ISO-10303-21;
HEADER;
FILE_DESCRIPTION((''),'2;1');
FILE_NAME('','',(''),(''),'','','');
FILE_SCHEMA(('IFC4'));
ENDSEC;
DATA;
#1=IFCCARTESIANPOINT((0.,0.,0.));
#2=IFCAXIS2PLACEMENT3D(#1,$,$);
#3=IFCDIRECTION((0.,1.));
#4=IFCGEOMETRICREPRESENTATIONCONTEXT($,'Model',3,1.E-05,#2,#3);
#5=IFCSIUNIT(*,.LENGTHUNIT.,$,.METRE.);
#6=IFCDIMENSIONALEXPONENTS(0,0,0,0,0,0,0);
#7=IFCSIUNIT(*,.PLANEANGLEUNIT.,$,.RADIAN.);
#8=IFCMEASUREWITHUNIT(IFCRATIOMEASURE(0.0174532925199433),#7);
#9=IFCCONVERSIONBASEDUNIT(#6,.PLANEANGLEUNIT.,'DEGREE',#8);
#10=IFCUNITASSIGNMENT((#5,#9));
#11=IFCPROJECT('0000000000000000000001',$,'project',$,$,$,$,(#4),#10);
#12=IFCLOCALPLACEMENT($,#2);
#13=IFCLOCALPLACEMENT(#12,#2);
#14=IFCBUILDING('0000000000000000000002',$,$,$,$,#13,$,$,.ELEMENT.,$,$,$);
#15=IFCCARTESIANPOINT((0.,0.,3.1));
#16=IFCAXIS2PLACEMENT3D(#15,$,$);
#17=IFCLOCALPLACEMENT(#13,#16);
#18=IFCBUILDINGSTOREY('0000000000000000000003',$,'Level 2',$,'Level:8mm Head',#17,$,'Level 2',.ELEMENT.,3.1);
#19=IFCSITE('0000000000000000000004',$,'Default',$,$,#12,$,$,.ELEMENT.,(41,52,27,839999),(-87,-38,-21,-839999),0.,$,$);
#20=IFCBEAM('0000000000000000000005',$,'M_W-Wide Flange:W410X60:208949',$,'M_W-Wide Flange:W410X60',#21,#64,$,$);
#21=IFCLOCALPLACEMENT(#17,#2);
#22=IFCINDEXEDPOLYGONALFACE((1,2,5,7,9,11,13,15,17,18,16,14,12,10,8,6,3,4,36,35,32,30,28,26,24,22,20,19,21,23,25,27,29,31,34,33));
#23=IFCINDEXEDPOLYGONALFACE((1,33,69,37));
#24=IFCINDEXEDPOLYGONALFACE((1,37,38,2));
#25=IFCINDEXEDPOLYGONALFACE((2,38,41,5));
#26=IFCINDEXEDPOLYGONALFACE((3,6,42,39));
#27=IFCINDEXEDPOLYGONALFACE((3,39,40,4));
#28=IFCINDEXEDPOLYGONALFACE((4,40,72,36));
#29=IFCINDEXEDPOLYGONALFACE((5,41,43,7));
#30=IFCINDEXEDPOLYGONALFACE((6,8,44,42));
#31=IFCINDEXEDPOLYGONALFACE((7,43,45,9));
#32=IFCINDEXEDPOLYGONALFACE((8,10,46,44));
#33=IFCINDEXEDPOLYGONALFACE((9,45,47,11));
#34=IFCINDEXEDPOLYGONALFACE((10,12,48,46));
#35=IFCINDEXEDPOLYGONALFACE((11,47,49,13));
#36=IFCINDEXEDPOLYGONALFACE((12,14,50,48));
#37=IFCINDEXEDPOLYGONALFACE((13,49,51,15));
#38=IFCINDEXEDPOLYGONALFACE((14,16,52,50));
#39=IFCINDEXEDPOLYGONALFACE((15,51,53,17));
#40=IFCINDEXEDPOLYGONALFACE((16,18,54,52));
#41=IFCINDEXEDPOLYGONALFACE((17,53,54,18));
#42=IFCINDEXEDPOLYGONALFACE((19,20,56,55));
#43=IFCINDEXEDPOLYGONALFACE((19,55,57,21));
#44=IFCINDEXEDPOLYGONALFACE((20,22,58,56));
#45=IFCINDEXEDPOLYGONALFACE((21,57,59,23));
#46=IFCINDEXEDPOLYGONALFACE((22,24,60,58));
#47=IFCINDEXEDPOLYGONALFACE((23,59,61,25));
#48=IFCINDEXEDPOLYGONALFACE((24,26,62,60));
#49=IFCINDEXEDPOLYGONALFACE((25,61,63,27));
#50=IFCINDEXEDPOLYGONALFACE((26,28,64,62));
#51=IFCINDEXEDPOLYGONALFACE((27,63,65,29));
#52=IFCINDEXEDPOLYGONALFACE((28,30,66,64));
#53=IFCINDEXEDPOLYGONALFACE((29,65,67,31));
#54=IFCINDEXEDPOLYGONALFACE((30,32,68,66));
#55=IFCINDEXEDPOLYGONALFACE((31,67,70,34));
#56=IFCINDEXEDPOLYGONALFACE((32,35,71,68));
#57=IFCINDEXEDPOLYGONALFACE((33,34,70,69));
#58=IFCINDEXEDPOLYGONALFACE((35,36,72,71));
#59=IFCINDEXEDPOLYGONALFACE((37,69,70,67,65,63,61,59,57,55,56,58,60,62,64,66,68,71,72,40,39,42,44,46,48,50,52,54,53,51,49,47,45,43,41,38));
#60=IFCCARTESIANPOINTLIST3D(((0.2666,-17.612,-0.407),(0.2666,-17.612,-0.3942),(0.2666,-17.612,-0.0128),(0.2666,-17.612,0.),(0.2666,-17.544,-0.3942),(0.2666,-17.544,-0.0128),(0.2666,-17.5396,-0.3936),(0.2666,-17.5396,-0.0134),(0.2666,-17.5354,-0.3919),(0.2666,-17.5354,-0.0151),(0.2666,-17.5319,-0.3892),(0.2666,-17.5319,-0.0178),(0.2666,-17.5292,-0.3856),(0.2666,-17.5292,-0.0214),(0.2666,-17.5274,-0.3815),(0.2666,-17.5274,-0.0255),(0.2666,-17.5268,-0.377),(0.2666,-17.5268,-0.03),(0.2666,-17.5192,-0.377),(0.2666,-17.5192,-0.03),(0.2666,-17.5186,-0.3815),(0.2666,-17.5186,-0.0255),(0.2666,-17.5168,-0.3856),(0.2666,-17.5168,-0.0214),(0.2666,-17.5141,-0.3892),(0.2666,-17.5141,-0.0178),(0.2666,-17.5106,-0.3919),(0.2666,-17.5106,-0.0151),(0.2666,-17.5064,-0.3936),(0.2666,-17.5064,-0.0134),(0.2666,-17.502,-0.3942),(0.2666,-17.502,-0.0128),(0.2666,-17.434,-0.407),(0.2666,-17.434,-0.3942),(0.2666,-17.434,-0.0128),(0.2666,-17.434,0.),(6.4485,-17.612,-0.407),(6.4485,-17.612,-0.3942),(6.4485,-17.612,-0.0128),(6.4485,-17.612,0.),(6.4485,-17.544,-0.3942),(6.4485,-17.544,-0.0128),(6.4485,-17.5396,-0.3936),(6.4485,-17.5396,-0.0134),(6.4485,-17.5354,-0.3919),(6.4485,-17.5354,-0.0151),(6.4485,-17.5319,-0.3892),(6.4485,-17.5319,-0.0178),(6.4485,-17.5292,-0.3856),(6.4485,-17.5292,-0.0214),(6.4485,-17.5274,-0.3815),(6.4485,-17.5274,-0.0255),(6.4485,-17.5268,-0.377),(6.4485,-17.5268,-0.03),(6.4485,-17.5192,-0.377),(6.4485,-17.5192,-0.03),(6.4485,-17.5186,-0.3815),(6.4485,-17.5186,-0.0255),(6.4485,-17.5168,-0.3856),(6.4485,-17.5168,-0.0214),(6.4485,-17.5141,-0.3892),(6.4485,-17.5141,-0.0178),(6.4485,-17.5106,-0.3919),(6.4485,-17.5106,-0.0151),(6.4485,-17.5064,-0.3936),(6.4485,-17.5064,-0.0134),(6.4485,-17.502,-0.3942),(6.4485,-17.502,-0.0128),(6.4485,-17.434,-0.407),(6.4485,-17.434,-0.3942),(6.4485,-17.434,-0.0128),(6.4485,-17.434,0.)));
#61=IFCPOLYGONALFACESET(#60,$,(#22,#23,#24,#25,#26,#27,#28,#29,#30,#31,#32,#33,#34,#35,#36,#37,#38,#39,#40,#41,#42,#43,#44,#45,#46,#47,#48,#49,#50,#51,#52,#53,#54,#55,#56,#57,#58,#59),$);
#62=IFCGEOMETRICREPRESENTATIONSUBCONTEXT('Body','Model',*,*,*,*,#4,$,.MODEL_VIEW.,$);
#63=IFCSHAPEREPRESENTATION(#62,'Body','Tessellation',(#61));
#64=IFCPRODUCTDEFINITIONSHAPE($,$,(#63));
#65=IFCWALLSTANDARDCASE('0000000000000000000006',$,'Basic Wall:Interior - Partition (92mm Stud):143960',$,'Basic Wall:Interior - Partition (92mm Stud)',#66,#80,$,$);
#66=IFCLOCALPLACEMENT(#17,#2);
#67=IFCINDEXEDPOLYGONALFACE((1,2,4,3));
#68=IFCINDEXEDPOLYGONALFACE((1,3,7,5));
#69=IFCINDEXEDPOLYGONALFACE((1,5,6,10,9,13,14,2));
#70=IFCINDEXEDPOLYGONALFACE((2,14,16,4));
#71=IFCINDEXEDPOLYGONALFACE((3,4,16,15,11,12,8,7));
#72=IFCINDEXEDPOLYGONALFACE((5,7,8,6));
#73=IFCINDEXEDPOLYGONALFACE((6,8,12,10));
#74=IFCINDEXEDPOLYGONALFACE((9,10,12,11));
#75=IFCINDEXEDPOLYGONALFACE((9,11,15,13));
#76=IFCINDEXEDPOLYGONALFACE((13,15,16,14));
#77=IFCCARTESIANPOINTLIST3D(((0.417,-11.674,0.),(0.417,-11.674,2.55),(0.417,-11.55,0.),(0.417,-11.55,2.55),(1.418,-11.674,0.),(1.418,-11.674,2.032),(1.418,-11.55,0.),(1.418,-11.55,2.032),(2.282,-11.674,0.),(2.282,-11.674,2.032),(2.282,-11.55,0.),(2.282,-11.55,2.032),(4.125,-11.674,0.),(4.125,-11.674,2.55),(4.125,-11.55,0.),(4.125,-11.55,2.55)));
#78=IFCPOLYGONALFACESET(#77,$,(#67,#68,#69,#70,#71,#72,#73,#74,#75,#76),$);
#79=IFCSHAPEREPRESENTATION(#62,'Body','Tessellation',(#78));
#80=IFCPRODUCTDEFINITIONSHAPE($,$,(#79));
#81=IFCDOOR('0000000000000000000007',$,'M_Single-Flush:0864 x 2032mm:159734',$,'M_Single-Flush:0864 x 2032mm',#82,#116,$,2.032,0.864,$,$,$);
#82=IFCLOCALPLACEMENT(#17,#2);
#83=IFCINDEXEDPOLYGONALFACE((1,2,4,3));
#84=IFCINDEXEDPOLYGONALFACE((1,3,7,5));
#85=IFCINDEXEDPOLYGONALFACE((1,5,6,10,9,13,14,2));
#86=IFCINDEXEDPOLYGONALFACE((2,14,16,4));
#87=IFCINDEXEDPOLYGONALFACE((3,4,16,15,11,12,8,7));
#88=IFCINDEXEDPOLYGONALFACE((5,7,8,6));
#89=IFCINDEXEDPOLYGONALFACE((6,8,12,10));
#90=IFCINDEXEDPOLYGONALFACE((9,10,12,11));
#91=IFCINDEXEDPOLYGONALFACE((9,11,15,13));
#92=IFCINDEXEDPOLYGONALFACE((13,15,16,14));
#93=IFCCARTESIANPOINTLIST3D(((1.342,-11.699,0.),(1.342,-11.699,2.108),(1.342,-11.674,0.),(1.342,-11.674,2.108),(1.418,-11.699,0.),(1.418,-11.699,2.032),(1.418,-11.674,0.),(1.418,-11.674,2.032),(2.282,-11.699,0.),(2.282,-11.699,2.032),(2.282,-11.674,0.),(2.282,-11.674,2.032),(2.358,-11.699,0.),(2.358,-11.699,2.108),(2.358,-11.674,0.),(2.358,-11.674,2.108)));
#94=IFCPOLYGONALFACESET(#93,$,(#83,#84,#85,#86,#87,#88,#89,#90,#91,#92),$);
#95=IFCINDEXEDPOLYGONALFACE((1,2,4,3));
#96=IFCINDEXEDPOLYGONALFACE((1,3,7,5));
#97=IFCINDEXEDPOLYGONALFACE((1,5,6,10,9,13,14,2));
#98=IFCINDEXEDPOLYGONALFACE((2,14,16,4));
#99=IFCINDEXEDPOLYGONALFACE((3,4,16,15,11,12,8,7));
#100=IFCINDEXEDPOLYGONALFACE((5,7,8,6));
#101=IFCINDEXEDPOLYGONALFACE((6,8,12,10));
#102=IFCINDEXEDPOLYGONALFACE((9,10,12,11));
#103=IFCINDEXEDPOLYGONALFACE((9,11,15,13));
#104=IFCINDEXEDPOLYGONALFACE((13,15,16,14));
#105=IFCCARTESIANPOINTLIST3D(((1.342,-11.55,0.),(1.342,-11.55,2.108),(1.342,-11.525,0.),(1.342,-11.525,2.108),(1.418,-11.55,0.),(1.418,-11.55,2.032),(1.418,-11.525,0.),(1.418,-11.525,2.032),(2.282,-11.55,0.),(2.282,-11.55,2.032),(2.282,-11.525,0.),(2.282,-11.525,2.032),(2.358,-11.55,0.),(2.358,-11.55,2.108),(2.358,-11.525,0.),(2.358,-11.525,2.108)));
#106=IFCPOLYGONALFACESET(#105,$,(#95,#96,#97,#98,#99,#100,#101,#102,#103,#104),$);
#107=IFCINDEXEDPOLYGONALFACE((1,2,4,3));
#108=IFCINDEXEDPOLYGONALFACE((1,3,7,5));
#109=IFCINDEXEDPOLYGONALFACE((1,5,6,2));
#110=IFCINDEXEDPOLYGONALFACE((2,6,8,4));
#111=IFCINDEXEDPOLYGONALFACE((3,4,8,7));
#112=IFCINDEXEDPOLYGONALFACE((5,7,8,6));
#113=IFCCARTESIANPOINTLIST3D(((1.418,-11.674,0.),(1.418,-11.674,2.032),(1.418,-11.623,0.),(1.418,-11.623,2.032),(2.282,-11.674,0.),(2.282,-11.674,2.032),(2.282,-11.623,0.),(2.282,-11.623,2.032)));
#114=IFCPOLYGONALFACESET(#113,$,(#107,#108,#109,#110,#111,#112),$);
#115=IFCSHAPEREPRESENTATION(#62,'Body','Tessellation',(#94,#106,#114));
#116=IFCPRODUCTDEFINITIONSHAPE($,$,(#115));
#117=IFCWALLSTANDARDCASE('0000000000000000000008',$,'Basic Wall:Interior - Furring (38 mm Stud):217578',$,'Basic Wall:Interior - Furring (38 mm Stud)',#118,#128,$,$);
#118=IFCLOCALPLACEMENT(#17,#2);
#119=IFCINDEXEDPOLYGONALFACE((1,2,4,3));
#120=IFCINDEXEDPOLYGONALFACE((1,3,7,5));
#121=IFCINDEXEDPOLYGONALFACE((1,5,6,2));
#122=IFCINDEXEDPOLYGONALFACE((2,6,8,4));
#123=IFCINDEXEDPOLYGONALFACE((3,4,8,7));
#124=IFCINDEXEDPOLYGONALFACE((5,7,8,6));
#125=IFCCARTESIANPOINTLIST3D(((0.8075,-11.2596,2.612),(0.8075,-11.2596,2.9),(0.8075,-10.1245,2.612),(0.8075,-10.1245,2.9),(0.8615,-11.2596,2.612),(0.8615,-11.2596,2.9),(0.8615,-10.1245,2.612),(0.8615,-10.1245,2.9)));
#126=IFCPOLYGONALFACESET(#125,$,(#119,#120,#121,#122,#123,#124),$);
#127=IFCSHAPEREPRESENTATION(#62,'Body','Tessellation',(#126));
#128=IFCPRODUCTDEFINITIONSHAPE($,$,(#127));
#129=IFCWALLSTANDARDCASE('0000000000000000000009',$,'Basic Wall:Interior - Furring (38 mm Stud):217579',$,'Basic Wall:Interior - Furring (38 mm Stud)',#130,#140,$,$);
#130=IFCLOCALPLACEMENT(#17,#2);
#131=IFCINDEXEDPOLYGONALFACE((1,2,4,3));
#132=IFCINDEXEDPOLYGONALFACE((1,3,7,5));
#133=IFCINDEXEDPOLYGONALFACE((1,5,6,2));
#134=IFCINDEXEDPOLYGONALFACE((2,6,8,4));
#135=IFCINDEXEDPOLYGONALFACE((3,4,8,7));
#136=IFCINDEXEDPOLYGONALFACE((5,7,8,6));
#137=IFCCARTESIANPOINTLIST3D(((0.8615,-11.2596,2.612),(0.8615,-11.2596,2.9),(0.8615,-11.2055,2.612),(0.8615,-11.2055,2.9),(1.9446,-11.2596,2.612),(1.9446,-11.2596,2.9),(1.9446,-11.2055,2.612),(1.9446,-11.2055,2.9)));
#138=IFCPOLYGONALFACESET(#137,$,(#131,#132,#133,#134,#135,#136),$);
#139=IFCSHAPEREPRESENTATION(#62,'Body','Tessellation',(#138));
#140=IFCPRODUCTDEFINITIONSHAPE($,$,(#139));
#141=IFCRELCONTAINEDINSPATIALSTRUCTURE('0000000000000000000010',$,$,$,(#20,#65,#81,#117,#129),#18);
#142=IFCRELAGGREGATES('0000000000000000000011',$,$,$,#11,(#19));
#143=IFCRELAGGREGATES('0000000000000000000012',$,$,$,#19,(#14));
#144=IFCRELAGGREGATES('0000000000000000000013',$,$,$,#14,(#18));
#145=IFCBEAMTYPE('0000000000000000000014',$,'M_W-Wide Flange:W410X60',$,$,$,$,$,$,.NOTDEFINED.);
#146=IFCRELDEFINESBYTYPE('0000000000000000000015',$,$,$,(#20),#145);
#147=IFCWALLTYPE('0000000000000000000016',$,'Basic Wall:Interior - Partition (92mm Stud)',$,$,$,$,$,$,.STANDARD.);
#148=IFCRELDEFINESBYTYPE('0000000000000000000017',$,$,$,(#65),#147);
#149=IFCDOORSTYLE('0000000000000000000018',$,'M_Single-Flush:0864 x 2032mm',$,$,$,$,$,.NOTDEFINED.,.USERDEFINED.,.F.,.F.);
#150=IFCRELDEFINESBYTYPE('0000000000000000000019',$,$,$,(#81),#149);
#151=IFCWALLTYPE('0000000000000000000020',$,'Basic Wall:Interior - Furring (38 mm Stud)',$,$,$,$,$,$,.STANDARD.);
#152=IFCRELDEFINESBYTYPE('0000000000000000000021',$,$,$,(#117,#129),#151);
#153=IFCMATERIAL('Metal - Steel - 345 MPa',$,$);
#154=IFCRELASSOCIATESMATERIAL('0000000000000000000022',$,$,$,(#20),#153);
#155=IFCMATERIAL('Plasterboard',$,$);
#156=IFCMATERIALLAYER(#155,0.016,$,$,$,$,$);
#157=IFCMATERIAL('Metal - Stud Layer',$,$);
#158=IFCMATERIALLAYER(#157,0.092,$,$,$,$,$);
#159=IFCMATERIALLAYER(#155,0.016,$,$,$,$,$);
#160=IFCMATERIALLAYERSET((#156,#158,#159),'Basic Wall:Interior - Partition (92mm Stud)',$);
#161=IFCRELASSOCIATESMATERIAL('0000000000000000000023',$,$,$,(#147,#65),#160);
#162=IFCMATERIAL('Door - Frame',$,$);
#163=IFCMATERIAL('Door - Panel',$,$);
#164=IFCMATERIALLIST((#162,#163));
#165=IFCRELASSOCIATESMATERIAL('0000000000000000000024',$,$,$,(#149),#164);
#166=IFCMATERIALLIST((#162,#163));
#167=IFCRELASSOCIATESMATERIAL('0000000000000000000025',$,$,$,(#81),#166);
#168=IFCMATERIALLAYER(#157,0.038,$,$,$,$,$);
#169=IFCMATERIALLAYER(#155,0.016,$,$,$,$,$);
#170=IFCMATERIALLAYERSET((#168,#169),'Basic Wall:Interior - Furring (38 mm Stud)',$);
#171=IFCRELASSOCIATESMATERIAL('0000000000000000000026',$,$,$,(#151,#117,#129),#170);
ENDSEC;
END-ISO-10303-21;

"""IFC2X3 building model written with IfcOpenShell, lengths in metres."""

from ifc_helpers import new_model, entity, si_unit, converted_unit, direction, frame, frame_2d, origin, place, context, subcontext, project, spatial, polyline, rectangle, i_section, outline, extrude, source, transform, mapped, material, material_list, layer, layer_set, layer_usage, type_object, type_shapes, element, fill, save


model = new_model("IFC2X3")

# Units and contexts
model_context = context("Model", 3, precision=1e-05, world=origin(), true_north=direction((0.0, 1.0)))
body_context = subcontext(model_context, "Body", "Model", "MODEL_VIEW")
ifc_project = project(units=[si_unit("LENGTHUNIT", "METRE"), converted_unit("PLANEANGLEUNIT", "DEGREE", entity("IfcRatioMeasure", 0.0174532925199433), si_unit("PLANEANGLEUNIT", "RADIAN"), dimensions=[0, 0, 0, 0, 0, 0, 0])], contexts=[model_context])

# Site, building, storey
site_placement = place(None, origin())
site = spatial("IfcSite", under=ifc_project, at=site_placement, Name="Default", CompositionType="ELEMENT", RefLatitude=(41, 52, 27, 839999), RefLongitude=(-87, -38, -21, -839999), RefElevation=0.0)
building_placement = place(site_placement, origin())
building = spatial("IfcBuilding", under=site, at=building_placement, CompositionType="ELEMENT")
storey_placement = place(building_placement, frame((0.0, 0.0, 3.1)))
storey = spatial("IfcBuildingStorey", under=building, at=storey_placement, Name="Level 2", ObjectType="Level:8mm Head", LongName="Level 2", CompositionType="ELEMENT", Elevation=3.1)

# Beam
ifc_material_1 = material(Name="Metal - Steel - 345 MPa")
beam_type = type_object("IfcBeamType", Name="M_W-Wide Flange:W410X60", PredefinedType="NOTDEFINED")
beam_placement = place(storey_placement, frame((0.2666, -17.523, 0.0)))
element("IfcBeam", 1, at=beam_placement, inside=storey, type_object=beam_type, material=ifc_material_1, Name="M_W-Wide Flange:W410X60:208949", ObjectType="M_W-Wide Flange:W410X60", context=body_context, shape_type="SweptSolid", body=[
    extrude(i_section(OverallWidth=0.178, OverallDepth=0.407, WebThickness=0.0077, FlangeThickness=0.0128, FilletRadius=0.0172, at=frame_2d((0.0, 0.0), x_axis=(0.0, 1.0))), frame((0.0, 0.0, -0.2035), z_axis=(1.0, 0.0, 0.0), x_axis=(0.0, 0.0, -1.0)), (0.0, 0.0, 1.0), 6.1819),
])

# Shared definitions
ifc_material_2 = material(Name="Metal - Stud Layer")
ifc_material_3 = material(Name="Plasterboard")

# Wall, opening, door
ifc_layer_1 = layer(ifc_material_3, 0.016)
ifc_layer_2 = layer(ifc_material_2, 0.092)
ifc_layer_3 = layer(ifc_material_3, 0.016)
ifc_layer_set_1 = layer_set([ifc_layer_1, ifc_layer_2, ifc_layer_3], Name="Basic Wall:Interior - Partition (92mm Stud)")
ifc_layer_usage_1 = layer_usage(ifc_layer_set_1, "AXIS2", "NEGATIVE", 0.062)
wall_type_1 = type_object("IfcWallType", Name="Basic Wall:Interior - Partition (92mm Stud)", PredefinedType="STANDARD", material=ifc_layer_set_1)
wall_1_placement = place(storey_placement, frame((4.125, -11.612, 0.0), z_axis=(0.0, 0.0, 1.0), x_axis=(-1.0, 0.0, 0.0)))
wall_1 = element("IfcWallStandardCase", 2, at=wall_1_placement, inside=storey, type_object=wall_type_1, material=ifc_layer_usage_1, Name="Basic Wall:Interior - Partition (92mm Stud):143960", ObjectType="Basic Wall:Interior - Partition (92mm Stud)", context=body_context, shape_type="SweptSolid", body=[
    extrude(rectangle(XDim=3.708, YDim=0.124, at=frame_2d((1.854, 0.0), x_axis=(-1.0, 0.0))), origin(), (0.0, 0.0, 1.0), 2.55),
])
opening_1_placement = place(wall_1_placement, frame((1.843, -0.062, 0.0)))
opening_1 = element("IfcOpeningElement", 3, at=opening_1_placement, cuts=wall_1, ObjectType="Opening", context=body_context, shape_type="SweptSolid", body=[
    extrude(rectangle(XDim=0.864, YDim=2.032, at=frame_2d((1.016, 0.432), x_axis=(0.0, -1.0))), frame((0.0, 0.0, 0.0), z_axis=(0.0, 1.0, 0.0), x_axis=(0.0, 0.0, 1.0)), (0.0, 0.0, 1.0), 0.124),
])
ifc_material_4 = material(Name="Door - Frame")
ifc_material_5 = material(Name="Door - Panel")
ifc_material_list_1 = material_list([ifc_material_4, ifc_material_5])
ifc_material_list_2 = material_list([ifc_material_4, ifc_material_5])
door_style = type_object("IfcDoorStyle", Name="M_Single-Flush:0864 x 2032mm", ConstructionType="USERDEFINED", OperationType="NOTDEFINED", ParameterTakesPrecedence=False, Sizeable=False, material=ifc_material_list_2)
shared_shape_1 = source(origin(), body_context, "Body", "SweptSolid", [
    extrude(outline(polyline([(-0.508, -1.073), (0.508, -1.073), (0.508, 1.035), (0.432, 1.035), (0.432, -0.997), (-0.432, -0.997), (-0.432, 1.035), (-0.508, 1.035), (-0.508, -1.073)])), frame((0.432, 0.149, 1.035), z_axis=(0.0, -1.0, 0.0), x_axis=(-1.0, 0.0, 0.0)), (0.0, 0.0, 1.0), 0.025),
    extrude(outline(polyline([(-1.073, -0.508), (1.035, -0.508), (1.035, -0.432), (-0.997, -0.432), (-0.997, 0.432), (1.035, 0.432), (1.035, 0.508), (-1.073, 0.508), (-1.073, -0.508)])), frame((0.432, 0.0, 1.035), z_axis=(0.0, -1.0, 0.0), x_axis=(0.0, 0.0, -1.0)), (0.0, 0.0, 1.0), 0.025),
    extrude(rectangle(XDim=0.864, YDim=0.051, at=frame_2d((0.0, 0.0), x_axis=(1.0, 0.0))), frame((0.432, 0.0985, 0.0)), (0.0, 0.0, 1.0), 2.032),
])
type_shapes(door_style, [shared_shape_1])
door_placement = place(opening_1_placement, origin())
door = element("IfcDoor", 4, at=door_placement, inside=storey, type_object=door_style, material=ifc_material_list_1, Name="M_Single-Flush:0864 x 2032mm:159734", ObjectType="M_Single-Flush:0864 x 2032mm", OverallHeight=2.032, OverallWidth=0.864, context=body_context, shape_type="MappedRepresentation", body=[
    mapped(shared_shape_1, transform((0.0, 0.0, 0.0), scale=1.0)),
])
fill(opening_1, door)

# Walls
ifc_layer_4 = layer(ifc_material_2, 0.038)
ifc_layer_5 = layer(ifc_material_3, 0.016)
ifc_layer_set_2 = layer_set([ifc_layer_4, ifc_layer_5], Name="Basic Wall:Interior - Furring (38 mm Stud)")
ifc_layer_usage_2 = layer_usage(ifc_layer_set_2, "AXIS2", "NEGATIVE", 0.027)
wall_type_2 = type_object("IfcWallType", Name="Basic Wall:Interior - Furring (38 mm Stud)", PredefinedType="STANDARD", material=ifc_layer_set_2)
wall_2_placement = place(storey_placement, frame((0.8345, -11.2596, 2.612), z_axis=(0.0, 0.0, 1.0), x_axis=(0.0, 1.0, 0.0)))
element("IfcWallStandardCase", 5, at=wall_2_placement, inside=storey, type_object=wall_type_2, material=ifc_layer_usage_2, Name="Basic Wall:Interior - Furring (38 mm Stud):217578", ObjectType="Basic Wall:Interior - Furring (38 mm Stud)", context=body_context, shape_type="SweptSolid", body=[
    extrude(rectangle(XDim=1.1351, YDim=0.054, at=frame_2d((0.5675, 0.0), x_axis=(-1.0, 0.0))), origin(), (0.0, 0.0, 1.0), 0.288),
])
ifc_layer_usage_3 = layer_usage(ifc_layer_set_2, "AXIS2", "NEGATIVE", 0.027)
wall_3_placement = place(storey_placement, frame((1.9446, -11.2325, 2.612), z_axis=(0.0, 0.0, 1.0), x_axis=(-1.0, 0.0, 0.0)))
element("IfcWallStandardCase", 6, at=wall_3_placement, inside=storey, type_object=wall_type_2, material=ifc_layer_usage_3, Name="Basic Wall:Interior - Furring (38 mm Stud):217579", ObjectType="Basic Wall:Interior - Furring (38 mm Stud)", context=body_context, shape_type="SweptSolid", body=[
    extrude(rectangle(XDim=1.0831, YDim=0.054, at=frame_2d((0.5415, 0.0), x_axis=(-1.0, 0.0))), origin(), (0.0, 0.0, 1.0), 0.288),
])

save(model, "model.ifc")
